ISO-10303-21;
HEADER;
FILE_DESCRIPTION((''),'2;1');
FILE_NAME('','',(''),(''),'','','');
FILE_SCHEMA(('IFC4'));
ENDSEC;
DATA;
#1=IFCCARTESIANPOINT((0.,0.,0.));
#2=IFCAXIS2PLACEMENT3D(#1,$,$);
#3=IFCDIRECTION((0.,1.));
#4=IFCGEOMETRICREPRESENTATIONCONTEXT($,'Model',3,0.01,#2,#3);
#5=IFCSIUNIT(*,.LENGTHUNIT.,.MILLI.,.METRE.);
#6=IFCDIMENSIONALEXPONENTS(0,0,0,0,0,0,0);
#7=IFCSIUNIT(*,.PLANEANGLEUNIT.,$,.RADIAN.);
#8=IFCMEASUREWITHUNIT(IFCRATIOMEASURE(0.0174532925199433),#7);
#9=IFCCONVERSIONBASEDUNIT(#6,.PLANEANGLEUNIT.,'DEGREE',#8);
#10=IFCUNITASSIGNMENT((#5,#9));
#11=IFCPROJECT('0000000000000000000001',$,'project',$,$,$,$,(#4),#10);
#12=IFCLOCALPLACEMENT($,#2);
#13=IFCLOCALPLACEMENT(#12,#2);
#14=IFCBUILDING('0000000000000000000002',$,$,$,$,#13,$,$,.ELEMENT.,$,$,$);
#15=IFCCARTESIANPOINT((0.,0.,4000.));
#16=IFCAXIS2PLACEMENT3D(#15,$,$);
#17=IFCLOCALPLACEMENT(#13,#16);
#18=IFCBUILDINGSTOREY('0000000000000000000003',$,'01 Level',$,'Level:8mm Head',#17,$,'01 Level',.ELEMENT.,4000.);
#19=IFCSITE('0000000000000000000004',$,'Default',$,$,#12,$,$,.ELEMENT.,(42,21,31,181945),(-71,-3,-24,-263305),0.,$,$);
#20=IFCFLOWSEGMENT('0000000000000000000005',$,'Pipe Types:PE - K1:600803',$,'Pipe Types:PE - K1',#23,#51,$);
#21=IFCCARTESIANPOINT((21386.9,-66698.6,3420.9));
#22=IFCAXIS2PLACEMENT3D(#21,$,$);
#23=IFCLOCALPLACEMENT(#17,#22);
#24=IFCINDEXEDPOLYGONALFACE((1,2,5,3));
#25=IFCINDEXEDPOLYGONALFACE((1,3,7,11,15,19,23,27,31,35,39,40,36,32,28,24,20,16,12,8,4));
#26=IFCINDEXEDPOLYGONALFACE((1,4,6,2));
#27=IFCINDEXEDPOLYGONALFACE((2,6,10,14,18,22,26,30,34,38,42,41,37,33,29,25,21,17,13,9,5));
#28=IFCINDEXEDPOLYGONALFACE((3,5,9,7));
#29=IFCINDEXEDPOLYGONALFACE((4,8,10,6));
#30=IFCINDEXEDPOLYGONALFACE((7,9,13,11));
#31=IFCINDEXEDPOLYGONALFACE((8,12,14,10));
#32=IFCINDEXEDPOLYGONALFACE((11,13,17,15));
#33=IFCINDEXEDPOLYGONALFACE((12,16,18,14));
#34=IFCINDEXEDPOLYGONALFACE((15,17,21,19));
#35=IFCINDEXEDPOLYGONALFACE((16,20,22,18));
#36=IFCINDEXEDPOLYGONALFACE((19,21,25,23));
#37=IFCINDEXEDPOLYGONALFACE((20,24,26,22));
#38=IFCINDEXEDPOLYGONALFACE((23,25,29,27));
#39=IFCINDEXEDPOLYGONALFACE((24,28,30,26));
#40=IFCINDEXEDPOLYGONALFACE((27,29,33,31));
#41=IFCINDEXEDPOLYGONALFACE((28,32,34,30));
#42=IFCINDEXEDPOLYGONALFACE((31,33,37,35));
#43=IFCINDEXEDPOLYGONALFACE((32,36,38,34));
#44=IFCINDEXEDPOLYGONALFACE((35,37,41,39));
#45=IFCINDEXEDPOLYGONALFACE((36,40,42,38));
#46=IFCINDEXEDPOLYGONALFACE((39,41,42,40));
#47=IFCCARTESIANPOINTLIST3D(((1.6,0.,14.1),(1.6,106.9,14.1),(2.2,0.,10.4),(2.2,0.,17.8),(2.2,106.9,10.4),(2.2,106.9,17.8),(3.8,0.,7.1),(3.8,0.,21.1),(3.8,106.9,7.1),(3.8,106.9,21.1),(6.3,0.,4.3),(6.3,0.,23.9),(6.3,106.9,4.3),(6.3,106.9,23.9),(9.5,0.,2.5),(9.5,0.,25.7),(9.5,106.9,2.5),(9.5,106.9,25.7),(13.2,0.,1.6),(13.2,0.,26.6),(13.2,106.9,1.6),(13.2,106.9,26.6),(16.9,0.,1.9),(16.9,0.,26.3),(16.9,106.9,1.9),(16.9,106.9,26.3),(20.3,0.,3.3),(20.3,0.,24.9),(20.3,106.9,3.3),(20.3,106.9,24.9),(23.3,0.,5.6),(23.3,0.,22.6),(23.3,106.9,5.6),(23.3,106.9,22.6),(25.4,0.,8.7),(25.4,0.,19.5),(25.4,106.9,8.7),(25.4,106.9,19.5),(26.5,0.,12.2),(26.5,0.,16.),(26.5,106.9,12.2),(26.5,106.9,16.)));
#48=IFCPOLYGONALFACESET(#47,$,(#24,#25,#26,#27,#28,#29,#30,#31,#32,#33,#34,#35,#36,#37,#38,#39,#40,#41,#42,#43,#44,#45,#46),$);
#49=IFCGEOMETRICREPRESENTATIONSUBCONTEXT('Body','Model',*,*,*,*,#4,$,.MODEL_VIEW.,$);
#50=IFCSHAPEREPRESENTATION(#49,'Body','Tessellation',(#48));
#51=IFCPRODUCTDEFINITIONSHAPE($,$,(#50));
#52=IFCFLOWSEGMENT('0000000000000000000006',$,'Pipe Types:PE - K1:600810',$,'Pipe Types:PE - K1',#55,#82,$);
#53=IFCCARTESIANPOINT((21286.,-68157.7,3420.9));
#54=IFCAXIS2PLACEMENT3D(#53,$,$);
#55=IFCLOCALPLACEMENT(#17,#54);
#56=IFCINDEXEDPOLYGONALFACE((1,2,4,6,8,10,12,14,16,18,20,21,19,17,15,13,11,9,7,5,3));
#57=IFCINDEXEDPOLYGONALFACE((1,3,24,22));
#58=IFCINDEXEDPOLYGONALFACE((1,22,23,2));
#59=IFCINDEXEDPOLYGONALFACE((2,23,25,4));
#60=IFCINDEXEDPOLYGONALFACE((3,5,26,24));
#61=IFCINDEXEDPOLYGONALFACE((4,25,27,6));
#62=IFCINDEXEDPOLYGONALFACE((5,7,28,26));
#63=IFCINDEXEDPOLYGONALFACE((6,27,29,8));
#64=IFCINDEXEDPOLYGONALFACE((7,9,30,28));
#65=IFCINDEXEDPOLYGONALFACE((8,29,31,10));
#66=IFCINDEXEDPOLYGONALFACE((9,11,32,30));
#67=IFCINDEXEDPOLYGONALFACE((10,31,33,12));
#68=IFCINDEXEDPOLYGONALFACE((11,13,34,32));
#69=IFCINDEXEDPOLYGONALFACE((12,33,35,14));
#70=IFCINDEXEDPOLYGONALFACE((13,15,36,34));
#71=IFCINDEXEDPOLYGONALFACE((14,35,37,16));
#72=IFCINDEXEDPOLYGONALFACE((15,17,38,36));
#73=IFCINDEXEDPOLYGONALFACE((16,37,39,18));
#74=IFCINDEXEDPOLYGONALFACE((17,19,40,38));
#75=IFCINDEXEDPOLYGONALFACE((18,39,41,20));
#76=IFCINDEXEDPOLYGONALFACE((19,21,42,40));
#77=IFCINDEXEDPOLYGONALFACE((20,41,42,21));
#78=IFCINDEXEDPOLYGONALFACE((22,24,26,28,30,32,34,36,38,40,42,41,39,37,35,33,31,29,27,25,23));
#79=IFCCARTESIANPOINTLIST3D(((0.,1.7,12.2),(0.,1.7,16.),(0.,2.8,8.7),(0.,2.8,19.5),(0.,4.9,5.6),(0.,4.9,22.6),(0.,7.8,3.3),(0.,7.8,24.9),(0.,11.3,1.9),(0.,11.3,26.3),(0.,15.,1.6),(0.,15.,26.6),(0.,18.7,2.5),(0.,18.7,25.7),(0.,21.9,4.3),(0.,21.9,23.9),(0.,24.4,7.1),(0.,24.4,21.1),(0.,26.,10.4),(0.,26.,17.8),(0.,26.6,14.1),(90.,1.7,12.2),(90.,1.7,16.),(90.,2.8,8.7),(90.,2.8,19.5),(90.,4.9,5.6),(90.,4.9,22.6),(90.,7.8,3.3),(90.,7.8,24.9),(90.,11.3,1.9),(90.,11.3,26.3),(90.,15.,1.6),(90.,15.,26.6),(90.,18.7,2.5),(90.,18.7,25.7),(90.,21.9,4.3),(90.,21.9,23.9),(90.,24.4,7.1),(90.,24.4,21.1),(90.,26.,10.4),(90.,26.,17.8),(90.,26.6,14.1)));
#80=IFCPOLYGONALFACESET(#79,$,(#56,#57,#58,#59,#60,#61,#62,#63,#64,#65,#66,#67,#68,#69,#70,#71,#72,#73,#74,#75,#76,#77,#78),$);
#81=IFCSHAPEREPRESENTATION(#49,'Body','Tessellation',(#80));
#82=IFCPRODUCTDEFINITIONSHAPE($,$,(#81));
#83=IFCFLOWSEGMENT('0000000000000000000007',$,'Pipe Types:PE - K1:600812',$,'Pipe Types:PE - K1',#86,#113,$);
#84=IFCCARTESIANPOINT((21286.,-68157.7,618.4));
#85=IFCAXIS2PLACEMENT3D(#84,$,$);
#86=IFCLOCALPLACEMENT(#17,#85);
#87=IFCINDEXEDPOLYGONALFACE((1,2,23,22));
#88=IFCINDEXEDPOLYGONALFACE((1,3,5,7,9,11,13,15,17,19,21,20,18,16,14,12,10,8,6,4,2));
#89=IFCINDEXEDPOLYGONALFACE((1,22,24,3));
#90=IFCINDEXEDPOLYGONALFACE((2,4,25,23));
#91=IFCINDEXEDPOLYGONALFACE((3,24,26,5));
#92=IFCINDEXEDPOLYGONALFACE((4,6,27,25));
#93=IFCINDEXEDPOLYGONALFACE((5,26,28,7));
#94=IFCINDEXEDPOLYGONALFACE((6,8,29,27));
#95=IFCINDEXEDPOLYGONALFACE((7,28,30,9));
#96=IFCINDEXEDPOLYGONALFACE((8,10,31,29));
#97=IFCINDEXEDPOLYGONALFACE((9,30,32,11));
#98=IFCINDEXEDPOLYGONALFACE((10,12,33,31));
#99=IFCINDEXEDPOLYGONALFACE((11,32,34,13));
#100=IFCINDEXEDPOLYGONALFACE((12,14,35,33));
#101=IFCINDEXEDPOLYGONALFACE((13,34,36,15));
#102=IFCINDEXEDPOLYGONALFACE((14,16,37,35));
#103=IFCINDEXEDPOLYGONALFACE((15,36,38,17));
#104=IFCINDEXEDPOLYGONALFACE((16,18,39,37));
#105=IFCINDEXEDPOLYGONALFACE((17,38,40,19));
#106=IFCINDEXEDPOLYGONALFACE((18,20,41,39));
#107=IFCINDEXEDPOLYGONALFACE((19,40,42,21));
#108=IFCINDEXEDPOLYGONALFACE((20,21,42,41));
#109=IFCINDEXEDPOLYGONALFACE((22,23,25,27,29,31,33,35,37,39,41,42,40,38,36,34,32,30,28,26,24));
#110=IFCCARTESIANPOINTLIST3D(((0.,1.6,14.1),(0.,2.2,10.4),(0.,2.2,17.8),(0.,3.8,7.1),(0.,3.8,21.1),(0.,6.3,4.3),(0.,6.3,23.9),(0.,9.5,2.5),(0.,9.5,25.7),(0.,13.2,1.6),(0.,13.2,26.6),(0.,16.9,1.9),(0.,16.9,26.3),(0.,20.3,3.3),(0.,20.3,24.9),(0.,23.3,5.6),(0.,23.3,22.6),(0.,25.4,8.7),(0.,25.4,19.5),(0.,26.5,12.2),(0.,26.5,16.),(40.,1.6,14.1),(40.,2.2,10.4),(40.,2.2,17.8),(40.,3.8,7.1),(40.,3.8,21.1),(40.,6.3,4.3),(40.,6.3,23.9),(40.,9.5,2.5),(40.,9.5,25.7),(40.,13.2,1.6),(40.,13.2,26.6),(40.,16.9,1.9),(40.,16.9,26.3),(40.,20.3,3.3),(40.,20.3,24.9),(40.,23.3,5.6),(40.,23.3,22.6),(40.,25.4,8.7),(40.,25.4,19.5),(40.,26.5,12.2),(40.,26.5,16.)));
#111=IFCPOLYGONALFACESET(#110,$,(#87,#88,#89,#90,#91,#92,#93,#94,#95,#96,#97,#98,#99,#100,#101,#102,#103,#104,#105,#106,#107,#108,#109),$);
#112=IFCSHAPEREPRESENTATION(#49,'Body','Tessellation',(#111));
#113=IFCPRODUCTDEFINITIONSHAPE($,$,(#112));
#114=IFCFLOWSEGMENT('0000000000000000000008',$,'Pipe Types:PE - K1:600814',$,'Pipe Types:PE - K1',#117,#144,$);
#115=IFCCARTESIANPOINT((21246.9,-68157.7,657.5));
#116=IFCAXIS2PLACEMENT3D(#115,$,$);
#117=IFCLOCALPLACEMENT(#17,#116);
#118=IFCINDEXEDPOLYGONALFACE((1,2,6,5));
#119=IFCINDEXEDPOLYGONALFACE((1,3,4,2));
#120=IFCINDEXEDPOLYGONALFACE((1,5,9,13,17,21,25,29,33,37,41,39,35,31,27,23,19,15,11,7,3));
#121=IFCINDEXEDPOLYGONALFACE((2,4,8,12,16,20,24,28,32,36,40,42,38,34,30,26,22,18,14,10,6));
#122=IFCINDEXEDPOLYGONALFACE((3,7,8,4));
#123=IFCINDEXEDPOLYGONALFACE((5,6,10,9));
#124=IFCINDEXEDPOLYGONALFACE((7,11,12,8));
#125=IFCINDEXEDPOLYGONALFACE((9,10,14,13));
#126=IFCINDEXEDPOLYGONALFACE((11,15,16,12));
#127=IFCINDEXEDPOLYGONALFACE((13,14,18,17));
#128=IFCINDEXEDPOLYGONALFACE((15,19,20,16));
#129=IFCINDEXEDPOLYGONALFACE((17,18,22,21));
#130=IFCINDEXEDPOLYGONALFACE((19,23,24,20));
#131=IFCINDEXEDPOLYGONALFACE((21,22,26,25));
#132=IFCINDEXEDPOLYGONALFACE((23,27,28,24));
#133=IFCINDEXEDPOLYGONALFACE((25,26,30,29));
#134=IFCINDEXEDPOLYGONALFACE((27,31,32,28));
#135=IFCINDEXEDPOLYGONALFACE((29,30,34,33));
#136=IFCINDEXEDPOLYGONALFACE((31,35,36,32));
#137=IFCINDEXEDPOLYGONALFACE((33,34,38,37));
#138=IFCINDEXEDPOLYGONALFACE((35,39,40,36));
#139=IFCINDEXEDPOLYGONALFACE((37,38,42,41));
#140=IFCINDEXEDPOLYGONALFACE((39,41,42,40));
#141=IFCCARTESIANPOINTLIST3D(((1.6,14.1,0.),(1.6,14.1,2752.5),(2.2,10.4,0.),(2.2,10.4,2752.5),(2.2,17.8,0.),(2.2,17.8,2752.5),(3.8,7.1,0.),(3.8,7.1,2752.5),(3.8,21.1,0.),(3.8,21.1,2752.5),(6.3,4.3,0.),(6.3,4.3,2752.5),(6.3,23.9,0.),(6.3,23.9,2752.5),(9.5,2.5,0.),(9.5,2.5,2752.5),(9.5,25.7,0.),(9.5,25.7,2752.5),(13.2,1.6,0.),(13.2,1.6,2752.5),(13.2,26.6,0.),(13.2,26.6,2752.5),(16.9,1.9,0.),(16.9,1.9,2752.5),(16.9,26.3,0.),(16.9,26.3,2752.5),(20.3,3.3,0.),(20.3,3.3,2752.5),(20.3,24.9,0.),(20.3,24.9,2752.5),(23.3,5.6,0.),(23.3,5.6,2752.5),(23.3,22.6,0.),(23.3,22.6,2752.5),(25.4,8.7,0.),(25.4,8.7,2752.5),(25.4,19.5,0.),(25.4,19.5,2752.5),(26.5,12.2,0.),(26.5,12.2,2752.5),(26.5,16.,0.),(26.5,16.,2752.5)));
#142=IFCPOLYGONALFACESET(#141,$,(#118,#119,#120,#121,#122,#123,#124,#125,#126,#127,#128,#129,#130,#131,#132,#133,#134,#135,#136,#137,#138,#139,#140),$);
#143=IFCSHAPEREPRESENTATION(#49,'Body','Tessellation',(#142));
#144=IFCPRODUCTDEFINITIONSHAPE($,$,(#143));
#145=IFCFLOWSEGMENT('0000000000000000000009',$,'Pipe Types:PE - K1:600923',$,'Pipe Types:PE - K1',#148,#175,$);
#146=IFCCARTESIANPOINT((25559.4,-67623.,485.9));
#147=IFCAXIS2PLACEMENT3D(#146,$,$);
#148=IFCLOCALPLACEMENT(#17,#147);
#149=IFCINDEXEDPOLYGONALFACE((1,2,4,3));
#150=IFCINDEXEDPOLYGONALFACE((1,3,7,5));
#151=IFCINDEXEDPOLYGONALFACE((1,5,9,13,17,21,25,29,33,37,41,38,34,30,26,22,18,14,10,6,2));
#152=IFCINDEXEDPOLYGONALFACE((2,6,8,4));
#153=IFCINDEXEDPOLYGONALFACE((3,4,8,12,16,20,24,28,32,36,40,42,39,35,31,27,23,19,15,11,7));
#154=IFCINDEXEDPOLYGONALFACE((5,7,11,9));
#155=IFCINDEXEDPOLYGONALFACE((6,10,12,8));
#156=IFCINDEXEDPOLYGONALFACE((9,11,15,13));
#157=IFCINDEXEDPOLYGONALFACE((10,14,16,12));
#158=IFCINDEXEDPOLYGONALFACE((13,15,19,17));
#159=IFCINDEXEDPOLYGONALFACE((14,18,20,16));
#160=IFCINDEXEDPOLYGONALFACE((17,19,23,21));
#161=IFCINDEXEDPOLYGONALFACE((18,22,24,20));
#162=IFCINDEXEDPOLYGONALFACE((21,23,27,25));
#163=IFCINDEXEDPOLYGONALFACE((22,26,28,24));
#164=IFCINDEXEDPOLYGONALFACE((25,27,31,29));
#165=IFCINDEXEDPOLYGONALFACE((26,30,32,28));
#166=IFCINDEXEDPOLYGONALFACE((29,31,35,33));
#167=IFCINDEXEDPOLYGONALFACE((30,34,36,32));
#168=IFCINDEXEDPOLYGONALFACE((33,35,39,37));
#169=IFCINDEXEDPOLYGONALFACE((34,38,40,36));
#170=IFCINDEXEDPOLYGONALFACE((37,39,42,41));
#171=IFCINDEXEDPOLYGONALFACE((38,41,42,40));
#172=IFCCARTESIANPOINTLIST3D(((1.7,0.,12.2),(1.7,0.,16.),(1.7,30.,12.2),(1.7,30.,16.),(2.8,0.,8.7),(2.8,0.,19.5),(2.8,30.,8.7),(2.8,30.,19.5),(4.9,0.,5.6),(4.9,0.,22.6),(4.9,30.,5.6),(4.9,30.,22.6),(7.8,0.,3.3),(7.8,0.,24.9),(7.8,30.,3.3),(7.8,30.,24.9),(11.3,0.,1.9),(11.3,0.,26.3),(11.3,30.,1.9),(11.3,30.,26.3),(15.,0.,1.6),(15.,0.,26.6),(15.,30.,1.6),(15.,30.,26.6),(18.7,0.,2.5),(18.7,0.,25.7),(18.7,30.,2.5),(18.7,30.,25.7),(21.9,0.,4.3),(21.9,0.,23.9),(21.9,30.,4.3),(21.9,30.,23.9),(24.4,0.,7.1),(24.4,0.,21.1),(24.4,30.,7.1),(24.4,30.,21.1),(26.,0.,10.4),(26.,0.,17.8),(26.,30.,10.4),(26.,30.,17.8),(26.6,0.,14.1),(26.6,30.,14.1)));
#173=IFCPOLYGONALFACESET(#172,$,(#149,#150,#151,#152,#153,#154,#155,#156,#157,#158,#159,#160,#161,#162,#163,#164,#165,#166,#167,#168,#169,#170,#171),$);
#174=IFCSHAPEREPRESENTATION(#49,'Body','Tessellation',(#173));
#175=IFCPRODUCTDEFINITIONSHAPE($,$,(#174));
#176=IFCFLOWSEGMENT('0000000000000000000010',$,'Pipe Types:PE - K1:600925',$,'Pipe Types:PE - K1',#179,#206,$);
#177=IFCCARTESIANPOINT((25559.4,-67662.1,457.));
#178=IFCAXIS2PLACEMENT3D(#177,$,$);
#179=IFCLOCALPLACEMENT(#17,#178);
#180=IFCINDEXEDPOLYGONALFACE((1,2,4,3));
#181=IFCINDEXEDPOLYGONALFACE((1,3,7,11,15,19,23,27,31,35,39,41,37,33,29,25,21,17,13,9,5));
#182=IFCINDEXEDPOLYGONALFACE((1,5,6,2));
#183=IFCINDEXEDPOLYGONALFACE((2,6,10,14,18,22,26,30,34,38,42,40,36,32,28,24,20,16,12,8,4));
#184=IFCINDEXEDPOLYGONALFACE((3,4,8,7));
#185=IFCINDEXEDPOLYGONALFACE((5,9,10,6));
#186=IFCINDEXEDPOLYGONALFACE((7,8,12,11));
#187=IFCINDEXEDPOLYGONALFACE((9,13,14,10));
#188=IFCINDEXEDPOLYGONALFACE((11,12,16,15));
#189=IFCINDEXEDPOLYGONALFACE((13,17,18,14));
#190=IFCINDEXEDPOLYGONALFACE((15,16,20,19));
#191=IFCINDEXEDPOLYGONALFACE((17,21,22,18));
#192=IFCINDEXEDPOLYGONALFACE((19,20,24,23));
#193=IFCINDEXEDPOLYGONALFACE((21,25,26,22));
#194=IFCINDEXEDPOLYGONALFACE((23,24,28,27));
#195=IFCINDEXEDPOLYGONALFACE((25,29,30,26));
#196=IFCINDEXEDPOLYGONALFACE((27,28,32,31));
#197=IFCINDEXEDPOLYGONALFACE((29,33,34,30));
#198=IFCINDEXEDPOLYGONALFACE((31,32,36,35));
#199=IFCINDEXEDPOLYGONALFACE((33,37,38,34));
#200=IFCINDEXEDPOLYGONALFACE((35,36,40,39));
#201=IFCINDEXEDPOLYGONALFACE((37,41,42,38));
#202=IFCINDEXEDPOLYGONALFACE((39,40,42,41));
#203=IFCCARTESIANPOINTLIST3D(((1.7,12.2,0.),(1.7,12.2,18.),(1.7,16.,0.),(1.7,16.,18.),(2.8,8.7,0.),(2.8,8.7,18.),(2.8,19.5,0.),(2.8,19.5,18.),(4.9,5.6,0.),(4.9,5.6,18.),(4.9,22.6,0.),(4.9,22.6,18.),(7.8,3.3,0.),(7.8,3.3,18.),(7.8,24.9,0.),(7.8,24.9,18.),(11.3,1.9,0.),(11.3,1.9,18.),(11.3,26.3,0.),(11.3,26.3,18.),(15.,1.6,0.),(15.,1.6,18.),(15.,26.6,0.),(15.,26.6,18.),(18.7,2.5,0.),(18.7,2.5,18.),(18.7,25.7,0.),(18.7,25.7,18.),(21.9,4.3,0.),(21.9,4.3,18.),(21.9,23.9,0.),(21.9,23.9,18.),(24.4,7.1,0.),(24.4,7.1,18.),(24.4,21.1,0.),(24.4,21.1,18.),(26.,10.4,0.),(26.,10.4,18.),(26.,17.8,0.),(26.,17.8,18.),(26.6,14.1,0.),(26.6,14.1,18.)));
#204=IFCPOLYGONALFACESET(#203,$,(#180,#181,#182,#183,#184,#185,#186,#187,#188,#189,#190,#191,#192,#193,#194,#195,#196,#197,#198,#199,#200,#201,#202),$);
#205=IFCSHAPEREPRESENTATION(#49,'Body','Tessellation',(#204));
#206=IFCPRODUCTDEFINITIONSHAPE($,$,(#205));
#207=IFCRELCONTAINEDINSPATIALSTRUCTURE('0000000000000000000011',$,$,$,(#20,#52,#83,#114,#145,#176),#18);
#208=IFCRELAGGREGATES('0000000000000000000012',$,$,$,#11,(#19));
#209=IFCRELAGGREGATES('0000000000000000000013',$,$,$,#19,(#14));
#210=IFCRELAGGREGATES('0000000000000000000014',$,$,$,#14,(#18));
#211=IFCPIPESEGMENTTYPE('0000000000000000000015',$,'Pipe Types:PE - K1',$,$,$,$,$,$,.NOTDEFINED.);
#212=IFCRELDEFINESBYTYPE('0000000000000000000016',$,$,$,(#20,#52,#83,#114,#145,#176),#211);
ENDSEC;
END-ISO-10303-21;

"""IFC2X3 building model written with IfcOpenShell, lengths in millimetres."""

from ifc_helpers import new_model, entity, si_unit, converted_unit, direction, frame, frame_2d, origin, origin_2d_with_axis, place, context, subcontext, project, spatial, circle, extrude, type_object, element, save


model = new_model("IFC2X3")

# Units and contexts
model_context = context("Model", 3, precision=0.01, world=origin(), true_north=direction((0.0, 1.0)))
body_context = subcontext(model_context, "Body", "Model", "MODEL_VIEW")
ifc_project = project(units=[si_unit("LENGTHUNIT", "METRE", prefix="MILLI"), converted_unit("PLANEANGLEUNIT", "DEGREE", entity("IfcRatioMeasure", 0.0174532925199433), si_unit("PLANEANGLEUNIT", "RADIAN"), dimensions=[0, 0, 0, 0, 0, 0, 0])], contexts=[model_context])

# Site, building, storey
site_placement = place(None, origin())
site = spatial("IfcSite", under=ifc_project, at=site_placement, Name="Default", CompositionType="ELEMENT", RefLatitude=(42, 21, 31, 181945), RefLongitude=(-71, -3, -24, -263305), RefElevation=0.0)
building_placement = place(site_placement, origin())
building = spatial("IfcBuilding", under=site, at=building_placement, CompositionType="ELEMENT")
storey_placement = place(building_placement, frame((0.0, 0.0, 4000.0)))
storey = spatial("IfcBuildingStorey", under=building, at=storey_placement, Name="01 Level", ObjectType="Level:8mm Head", LongName="01 Level", CompositionType="ELEMENT", Elevation=4000.0)

# Flow segments
pipe_segment_type = type_object("IfcPipeSegmentType", Name="Pipe Types:PE - K1", PredefinedType="NOTDEFINED")
flow_segment_1_placement = place(storey_placement, frame((21386.9, -66698.6, 3420.9)))
element("IfcFlowSegment", 1, at=flow_segment_1_placement, inside=storey, type_object=pipe_segment_type, Name="Pipe Types:PE - K1:600803", ObjectType="Pipe Types:PE - K1", context=body_context, shape_type="SweptSolid", body=[
    extrude(circle(Radius=12.5, at=frame_2d((0.0, 0.0), x_axis=(1.0, 0.0))), frame((14.1, 0.0, 14.1), z_axis=(0.0, 1.0, 0.0), x_axis=(-1.0, 0.0, 0.0)), (0.0, 0.0, 1.0), 106.9),
])
flow_segment_2_placement = place(storey_placement, frame((21286.0, -68157.7, 3420.9)))
element("IfcFlowSegment", 2, at=flow_segment_2_placement, inside=storey, type_object=pipe_segment_type, Name="Pipe Types:PE - K1:600810", ObjectType="Pipe Types:PE - K1", context=body_context, shape_type="SweptSolid", body=[
    extrude(circle(Radius=12.5, at=origin_2d_with_axis()), frame((0.0, 14.1, 14.1), z_axis=(1.0, 0.0, 0.0), x_axis=(0.0, 1.0, 0.0)), (0.0, 0.0, 1.0), 90.0),
])
flow_segment_3_placement = place(storey_placement, frame((21286.0, -68157.7, 618.4)))
element("IfcFlowSegment", 3, at=flow_segment_3_placement, inside=storey, type_object=pipe_segment_type, Name="Pipe Types:PE - K1:600812", ObjectType="Pipe Types:PE - K1", context=body_context, shape_type="SweptSolid", body=[
    extrude(circle(Radius=12.5, at=origin_2d_with_axis()), frame((0.0, 14.1, 14.1), z_axis=(1.0, 0.0, 0.0), x_axis=(0.0, -1.0, 0.0)), (0.0, 0.0, 1.0), 40.0),
])
flow_segment_4_placement = place(storey_placement, frame((21246.9, -68157.7, 657.5)))
element("IfcFlowSegment", 4, at=flow_segment_4_placement, inside=storey, type_object=pipe_segment_type, Name="Pipe Types:PE - K1:600814", ObjectType="Pipe Types:PE - K1", context=body_context, shape_type="SweptSolid", body=[
    extrude(circle(Radius=12.5, at=origin_2d_with_axis()), frame((14.1, 14.1, 0.0), z_axis=(0.0, 0.0, 1.0), x_axis=(-1.0, 0.0, 0.0)), (0.0, 0.0, 1.0), 2752.5),
])
flow_segment_5_placement = place(storey_placement, frame((25559.4, -67623.0, 485.9)))
element("IfcFlowSegment", 5, at=flow_segment_5_placement, inside=storey, type_object=pipe_segment_type, Name="Pipe Types:PE - K1:600923", ObjectType="Pipe Types:PE - K1", context=body_context, shape_type="SweptSolid", body=[
    extrude(circle(Radius=12.5, at=frame_2d((0.0, 0.0), x_axis=(1.0, 0.0))), frame((14.1, 0.0, 14.1), z_axis=(0.0, 1.0, 0.0), x_axis=(1.0, 0.0, 0.0)), (0.0, 0.0, 1.0), 30.0),
])
flow_segment_6_placement = place(storey_placement, frame((25559.4, -67662.1, 457.0)))
element("IfcFlowSegment", 6, at=flow_segment_6_placement, inside=storey, type_object=pipe_segment_type, Name="Pipe Types:PE - K1:600925", ObjectType="Pipe Types:PE - K1", context=body_context, shape_type="SweptSolid", body=[
    extrude(circle(Radius=12.5, at=frame_2d((0.0, 0.0), x_axis=(1.0, 0.0))), frame((14.1, 14.1, 0.0)), (0.0, 0.0, 1.0), 18.0),
])

save(model, "model.ifc")
